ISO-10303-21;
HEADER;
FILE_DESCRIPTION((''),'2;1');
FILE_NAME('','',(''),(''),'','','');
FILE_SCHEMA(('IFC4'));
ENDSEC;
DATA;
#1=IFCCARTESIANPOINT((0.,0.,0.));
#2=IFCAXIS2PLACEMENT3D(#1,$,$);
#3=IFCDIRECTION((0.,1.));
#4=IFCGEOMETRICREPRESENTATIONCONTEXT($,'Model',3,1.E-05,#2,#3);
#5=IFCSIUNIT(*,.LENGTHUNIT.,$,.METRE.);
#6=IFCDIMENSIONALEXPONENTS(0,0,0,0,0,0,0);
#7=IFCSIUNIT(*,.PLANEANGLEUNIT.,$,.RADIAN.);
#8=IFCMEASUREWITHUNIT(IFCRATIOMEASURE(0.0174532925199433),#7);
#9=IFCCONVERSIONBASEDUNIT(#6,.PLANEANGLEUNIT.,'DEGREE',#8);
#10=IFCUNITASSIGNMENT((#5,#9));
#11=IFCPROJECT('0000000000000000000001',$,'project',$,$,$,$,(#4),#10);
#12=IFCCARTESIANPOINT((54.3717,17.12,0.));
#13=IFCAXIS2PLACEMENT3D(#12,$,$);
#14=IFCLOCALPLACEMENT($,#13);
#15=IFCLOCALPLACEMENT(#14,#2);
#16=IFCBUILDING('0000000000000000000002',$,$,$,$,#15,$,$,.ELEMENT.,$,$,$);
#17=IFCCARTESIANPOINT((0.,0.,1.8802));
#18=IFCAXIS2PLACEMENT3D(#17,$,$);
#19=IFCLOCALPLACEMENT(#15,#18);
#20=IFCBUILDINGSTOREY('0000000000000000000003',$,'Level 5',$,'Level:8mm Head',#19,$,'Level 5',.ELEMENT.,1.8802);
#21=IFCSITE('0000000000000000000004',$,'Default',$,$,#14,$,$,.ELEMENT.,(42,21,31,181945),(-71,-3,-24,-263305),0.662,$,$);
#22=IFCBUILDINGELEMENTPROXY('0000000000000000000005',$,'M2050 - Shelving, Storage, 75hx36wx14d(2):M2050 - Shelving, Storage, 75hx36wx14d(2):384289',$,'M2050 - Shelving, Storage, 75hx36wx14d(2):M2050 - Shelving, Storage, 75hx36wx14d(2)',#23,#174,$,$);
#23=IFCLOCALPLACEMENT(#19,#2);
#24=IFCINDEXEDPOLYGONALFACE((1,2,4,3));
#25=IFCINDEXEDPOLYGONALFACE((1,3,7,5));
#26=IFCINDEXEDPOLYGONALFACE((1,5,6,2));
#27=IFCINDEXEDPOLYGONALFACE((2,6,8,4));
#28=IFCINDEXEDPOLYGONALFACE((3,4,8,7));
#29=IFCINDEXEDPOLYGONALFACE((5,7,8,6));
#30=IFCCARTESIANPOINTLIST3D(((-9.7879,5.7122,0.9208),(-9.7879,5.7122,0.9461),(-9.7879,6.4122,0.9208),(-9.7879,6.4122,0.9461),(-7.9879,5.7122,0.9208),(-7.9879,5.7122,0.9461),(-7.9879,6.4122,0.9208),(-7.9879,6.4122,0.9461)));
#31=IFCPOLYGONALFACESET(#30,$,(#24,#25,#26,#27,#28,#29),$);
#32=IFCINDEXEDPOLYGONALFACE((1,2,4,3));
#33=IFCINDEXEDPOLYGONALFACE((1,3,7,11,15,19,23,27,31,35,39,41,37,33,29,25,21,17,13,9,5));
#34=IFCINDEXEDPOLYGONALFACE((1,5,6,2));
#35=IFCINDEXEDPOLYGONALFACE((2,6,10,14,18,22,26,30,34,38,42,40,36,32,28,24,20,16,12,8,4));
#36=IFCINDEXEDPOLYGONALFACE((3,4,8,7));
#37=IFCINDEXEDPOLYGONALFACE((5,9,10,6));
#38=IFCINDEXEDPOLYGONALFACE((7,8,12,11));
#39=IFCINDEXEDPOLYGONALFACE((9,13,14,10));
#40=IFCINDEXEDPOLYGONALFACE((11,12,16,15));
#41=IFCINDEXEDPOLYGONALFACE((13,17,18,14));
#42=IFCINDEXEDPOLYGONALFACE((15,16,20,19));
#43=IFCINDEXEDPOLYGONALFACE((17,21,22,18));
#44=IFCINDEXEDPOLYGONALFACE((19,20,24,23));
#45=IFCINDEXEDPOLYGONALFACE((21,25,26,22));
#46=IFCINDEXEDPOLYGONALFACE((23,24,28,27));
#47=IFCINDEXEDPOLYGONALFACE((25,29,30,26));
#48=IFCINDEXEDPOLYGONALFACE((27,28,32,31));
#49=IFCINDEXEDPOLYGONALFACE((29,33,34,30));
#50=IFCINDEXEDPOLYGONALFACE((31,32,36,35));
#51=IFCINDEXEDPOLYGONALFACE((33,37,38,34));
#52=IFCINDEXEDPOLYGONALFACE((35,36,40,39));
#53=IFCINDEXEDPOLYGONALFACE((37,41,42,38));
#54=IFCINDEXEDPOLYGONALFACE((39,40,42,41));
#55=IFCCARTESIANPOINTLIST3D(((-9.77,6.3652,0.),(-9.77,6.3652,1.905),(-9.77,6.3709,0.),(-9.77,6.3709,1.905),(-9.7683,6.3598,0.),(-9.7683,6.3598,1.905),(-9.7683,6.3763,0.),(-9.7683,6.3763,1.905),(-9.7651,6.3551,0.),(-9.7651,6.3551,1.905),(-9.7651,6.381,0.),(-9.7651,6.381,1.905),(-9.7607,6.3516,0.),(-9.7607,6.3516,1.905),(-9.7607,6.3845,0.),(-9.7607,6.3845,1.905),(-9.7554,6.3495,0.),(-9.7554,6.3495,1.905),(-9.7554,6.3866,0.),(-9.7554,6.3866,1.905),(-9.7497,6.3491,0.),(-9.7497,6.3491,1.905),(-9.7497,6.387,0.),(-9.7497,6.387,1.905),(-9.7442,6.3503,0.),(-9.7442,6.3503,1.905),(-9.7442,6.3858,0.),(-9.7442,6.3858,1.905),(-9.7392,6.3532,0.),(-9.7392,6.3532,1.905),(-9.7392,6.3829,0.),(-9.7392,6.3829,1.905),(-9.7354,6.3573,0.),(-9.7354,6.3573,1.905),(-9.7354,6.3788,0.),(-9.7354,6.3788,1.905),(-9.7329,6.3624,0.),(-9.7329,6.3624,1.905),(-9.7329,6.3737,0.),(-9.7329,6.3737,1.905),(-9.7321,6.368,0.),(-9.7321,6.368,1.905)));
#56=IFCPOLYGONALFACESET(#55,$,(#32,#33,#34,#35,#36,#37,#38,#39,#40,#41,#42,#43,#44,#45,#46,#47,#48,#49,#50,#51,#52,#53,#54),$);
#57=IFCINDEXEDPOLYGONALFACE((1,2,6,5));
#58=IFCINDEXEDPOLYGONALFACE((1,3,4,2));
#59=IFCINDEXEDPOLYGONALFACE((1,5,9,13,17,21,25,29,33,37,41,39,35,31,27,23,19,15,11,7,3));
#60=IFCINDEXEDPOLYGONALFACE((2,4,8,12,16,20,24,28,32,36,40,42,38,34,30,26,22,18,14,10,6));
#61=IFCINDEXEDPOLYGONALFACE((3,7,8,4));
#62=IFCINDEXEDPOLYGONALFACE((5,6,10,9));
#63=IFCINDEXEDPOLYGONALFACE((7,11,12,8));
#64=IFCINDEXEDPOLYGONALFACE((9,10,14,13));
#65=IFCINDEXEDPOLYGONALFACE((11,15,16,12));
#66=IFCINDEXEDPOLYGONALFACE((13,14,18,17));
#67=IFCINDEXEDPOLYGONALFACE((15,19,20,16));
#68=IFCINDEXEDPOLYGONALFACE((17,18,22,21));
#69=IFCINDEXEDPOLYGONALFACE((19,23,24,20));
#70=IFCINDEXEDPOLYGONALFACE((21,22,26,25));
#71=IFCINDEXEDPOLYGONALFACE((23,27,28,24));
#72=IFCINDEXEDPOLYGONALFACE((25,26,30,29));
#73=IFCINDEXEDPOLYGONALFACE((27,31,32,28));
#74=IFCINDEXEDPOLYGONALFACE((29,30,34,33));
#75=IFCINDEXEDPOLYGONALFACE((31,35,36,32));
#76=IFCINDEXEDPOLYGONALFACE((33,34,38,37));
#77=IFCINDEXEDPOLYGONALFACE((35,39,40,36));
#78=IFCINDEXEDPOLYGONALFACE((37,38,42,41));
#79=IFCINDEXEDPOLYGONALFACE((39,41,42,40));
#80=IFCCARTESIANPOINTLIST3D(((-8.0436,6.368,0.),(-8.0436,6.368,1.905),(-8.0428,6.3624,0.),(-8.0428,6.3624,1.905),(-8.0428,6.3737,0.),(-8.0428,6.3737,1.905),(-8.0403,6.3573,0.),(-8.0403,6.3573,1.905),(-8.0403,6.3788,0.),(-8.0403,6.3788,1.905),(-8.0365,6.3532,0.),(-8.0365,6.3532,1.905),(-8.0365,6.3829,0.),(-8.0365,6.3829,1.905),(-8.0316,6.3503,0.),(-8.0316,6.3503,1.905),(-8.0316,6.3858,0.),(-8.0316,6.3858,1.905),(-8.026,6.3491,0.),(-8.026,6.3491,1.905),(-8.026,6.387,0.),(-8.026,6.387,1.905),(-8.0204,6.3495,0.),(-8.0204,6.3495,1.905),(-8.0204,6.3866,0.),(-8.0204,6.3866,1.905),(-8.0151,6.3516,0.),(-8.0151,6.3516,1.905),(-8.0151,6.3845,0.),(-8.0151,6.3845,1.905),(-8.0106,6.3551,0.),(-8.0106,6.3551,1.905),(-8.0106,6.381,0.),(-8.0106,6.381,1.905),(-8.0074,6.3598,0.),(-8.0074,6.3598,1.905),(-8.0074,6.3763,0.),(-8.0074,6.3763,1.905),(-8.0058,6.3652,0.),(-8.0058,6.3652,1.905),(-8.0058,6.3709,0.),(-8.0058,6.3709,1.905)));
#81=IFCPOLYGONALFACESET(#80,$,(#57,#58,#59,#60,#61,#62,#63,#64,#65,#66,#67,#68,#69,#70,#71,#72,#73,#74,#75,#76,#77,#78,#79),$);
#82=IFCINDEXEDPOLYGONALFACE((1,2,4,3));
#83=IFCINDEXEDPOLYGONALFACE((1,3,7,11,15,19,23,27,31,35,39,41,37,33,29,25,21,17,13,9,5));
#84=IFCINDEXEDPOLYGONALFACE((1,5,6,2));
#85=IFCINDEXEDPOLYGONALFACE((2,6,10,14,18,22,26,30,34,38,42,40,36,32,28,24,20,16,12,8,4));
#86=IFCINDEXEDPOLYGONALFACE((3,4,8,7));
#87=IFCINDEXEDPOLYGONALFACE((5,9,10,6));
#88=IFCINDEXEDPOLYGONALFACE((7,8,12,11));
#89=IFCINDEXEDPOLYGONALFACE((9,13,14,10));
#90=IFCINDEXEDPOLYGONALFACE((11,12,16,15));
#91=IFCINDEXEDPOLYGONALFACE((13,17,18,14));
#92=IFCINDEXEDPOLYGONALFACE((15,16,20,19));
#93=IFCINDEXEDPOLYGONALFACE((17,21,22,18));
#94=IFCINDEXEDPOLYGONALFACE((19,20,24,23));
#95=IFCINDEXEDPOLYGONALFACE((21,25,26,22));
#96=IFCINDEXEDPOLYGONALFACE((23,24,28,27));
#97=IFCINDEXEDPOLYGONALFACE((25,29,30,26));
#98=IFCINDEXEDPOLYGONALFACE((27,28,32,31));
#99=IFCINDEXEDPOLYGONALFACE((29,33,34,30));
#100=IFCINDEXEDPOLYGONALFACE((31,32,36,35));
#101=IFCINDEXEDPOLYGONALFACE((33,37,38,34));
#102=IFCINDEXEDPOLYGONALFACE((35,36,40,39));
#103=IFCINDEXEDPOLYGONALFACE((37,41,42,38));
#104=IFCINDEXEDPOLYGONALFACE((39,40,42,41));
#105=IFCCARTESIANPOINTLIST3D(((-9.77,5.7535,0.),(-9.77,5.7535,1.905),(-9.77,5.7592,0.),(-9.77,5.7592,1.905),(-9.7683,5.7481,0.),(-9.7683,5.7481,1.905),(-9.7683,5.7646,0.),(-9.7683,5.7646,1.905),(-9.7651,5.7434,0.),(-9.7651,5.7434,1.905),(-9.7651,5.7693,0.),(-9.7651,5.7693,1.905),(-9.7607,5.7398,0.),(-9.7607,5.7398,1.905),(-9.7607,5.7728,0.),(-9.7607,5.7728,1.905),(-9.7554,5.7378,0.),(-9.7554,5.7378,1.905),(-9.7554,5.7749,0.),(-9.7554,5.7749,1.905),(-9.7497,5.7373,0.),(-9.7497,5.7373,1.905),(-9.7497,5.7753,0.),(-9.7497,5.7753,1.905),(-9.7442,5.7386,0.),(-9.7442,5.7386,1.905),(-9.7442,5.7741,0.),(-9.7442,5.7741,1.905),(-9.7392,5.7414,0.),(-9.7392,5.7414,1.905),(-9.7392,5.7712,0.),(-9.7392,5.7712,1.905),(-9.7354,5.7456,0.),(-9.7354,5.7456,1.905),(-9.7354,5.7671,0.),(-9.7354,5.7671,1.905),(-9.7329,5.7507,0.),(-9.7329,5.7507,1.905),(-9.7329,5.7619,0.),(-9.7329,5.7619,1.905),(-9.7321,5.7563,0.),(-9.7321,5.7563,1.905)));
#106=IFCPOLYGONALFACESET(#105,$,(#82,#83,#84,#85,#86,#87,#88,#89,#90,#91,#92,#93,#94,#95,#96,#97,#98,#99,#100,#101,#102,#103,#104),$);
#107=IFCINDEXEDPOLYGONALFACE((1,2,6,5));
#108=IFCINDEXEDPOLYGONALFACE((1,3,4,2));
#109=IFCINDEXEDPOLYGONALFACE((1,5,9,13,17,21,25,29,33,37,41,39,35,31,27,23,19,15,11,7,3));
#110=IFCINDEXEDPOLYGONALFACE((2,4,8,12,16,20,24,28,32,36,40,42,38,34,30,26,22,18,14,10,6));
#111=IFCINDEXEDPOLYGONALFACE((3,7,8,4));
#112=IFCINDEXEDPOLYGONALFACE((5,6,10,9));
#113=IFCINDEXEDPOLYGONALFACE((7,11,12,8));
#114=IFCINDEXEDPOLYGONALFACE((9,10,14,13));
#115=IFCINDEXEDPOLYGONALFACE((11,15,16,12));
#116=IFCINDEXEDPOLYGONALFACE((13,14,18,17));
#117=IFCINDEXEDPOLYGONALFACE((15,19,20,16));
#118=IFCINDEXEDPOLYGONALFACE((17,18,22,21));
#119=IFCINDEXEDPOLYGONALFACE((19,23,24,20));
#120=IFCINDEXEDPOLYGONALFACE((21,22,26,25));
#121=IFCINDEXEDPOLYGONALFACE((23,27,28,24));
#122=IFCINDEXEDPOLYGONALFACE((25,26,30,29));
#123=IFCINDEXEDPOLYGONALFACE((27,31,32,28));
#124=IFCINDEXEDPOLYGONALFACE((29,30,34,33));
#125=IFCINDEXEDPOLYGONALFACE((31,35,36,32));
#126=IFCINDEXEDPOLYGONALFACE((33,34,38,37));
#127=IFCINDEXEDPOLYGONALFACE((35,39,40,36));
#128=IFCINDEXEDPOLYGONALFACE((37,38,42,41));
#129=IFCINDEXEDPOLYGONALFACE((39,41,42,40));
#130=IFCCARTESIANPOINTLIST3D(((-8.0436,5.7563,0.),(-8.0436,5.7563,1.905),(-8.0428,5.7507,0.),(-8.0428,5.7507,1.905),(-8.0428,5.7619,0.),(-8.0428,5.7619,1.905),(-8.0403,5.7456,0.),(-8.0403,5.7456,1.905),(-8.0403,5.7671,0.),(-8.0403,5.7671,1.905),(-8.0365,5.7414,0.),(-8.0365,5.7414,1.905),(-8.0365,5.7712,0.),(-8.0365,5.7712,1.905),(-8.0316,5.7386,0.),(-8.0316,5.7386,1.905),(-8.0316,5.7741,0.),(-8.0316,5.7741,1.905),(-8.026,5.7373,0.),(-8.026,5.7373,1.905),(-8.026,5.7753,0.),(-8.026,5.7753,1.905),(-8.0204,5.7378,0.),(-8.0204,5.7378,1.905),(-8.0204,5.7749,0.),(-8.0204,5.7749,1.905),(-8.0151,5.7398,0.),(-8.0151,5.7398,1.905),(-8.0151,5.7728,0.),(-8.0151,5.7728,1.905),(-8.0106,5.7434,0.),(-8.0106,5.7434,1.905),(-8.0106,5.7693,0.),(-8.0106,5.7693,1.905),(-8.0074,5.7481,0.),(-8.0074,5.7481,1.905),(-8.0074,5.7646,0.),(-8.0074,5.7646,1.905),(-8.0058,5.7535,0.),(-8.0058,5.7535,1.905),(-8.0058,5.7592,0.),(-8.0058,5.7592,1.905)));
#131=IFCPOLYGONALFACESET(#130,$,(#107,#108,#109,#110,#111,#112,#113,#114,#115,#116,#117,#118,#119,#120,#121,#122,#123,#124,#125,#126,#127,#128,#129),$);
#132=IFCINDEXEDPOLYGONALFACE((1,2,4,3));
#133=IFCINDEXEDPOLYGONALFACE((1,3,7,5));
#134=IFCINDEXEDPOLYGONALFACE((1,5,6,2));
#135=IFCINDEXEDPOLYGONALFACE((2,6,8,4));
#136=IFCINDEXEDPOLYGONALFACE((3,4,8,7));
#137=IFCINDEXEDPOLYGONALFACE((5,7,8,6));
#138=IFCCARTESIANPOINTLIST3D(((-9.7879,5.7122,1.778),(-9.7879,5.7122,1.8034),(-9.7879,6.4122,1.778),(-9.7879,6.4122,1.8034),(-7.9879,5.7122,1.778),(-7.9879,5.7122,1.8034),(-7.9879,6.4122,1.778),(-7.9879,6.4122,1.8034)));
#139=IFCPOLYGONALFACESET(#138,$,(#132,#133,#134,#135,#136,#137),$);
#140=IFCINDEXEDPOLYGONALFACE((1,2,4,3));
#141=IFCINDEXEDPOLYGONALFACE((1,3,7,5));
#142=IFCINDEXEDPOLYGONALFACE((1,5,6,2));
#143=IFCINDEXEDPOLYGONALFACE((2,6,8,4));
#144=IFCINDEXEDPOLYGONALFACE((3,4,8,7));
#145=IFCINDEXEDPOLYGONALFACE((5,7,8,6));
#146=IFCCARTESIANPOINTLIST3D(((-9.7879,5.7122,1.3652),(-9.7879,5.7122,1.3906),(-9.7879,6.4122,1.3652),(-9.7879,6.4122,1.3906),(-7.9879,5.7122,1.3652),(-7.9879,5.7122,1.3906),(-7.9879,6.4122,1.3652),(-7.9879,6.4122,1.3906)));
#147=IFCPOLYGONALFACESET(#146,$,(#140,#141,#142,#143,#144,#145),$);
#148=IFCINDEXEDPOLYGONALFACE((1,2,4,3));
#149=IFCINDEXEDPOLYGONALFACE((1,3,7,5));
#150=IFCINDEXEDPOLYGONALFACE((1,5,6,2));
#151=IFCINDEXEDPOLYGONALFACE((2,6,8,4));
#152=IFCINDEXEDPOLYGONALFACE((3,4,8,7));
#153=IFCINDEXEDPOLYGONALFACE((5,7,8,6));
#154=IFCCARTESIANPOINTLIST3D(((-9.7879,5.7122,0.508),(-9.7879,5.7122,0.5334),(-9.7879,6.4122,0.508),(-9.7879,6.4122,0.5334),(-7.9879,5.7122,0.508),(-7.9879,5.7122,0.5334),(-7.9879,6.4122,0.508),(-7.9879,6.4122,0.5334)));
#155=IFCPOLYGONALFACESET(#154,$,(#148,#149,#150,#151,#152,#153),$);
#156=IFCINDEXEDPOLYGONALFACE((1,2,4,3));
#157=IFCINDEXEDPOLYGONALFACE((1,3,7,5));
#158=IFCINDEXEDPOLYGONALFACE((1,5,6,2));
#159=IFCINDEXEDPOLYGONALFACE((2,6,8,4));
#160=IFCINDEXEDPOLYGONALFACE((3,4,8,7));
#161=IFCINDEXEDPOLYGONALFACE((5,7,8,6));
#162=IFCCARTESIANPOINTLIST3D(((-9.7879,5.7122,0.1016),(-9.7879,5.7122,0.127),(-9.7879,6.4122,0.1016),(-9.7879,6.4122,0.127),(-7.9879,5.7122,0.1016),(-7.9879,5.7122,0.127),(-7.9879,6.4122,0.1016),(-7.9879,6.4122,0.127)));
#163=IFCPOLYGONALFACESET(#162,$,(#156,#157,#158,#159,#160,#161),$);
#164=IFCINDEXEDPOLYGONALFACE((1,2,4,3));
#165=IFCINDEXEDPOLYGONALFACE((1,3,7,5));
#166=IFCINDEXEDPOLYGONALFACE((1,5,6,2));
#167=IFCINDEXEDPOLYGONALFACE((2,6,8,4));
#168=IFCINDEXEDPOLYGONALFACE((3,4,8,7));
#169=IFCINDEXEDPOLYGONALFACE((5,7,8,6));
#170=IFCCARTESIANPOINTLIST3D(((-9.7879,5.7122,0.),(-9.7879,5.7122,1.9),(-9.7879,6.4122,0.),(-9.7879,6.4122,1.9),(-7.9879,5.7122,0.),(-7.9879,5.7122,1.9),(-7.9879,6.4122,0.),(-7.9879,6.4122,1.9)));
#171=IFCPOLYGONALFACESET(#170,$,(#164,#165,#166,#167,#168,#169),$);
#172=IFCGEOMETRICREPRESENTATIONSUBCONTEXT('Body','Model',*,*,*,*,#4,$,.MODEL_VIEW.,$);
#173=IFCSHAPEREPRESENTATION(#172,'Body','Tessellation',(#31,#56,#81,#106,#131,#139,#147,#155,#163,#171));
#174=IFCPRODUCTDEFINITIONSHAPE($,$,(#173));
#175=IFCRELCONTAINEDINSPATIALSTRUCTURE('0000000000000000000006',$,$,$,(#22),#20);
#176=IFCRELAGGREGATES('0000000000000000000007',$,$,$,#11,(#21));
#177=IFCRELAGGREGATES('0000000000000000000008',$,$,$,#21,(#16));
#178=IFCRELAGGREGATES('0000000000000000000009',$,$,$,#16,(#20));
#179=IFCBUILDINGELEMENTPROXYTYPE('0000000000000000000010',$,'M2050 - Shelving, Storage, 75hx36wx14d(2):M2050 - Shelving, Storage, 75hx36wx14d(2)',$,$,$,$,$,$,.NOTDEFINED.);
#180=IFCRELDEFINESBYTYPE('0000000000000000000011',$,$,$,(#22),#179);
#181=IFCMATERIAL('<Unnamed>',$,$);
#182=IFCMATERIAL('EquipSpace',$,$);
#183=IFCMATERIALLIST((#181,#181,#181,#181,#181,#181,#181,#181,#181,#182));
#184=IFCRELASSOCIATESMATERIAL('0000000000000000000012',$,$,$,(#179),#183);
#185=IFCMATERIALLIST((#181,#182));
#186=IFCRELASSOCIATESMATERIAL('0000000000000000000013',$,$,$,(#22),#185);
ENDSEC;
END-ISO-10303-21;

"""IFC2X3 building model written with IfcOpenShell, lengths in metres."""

from ifc_helpers import new_model, entity, si_unit, converted_unit, direction, frame, frame_2d, origin, origin_2d_with_axis, place, context, subcontext, project, spatial, rectangle, circle, extrude, source, transform, mapped, material, material_list, type_object, type_shapes, element, save


model = new_model("IFC2X3")

# Units and contexts
model_context = context("Model", 3, precision=1e-05, world=origin(), true_north=direction((0.0, 1.0)))
body_context = subcontext(model_context, "Body", "Model", "MODEL_VIEW")
ifc_project = project(units=[si_unit("LENGTHUNIT", "METRE"), converted_unit("PLANEANGLEUNIT", "DEGREE", entity("IfcRatioMeasure", 0.0174532925199433), si_unit("PLANEANGLEUNIT", "RADIAN"), dimensions=[0, 0, 0, 0, 0, 0, 0])], contexts=[model_context])

# Site, building, storey
site_placement = place(None, frame((54.3717, 17.12, 0.0)))
site = spatial("IfcSite", under=ifc_project, at=site_placement, Name="Default", CompositionType="ELEMENT", RefLatitude=(42, 21, 31, 181945), RefLongitude=(-71, -3, -24, -263305), RefElevation=0.662)
building_placement = place(site_placement, origin())
building = spatial("IfcBuilding", under=site, at=building_placement, CompositionType="ELEMENT")
storey_placement = place(building_placement, frame((0.0, 0.0, 1.8802)))
storey = spatial("IfcBuildingStorey", under=building, at=storey_placement, Name="Level 5", ObjectType="Level:8mm Head", LongName="Level 5", CompositionType="ELEMENT", Elevation=1.8802)

# Building element proxy
ifc_material_1 = material(Name="<Unnamed>")
ifc_material_2 = material(Name="EquipSpace")
ifc_material_list_1 = material_list([ifc_material_1, ifc_material_1, ifc_material_1, ifc_material_1, ifc_material_1, ifc_material_1, ifc_material_1, ifc_material_1, ifc_material_1, ifc_material_2])
building_element_proxy_type = type_object("IfcBuildingElementProxyType", Name="M2050 - Shelving, Storage, 75hx36wx14d(2):M2050 - Shelving, Storage, 75hx36wx14d(2)", PredefinedType="NOTDEFINED", material=ifc_material_list_1)
shared_shape = source(origin(), body_context, "Body", "SweptSolid", [
    extrude(rectangle(XDim=1.8, YDim=0.7, at=origin_2d_with_axis()), frame((0.0, 0.0, 0.9207), z_axis=(0.0, 0.0, 1.0), x_axis=(-1.0, 0.0, 0.0)), (0.0, 0.0, 1.0), 0.0254),
    extrude(circle(Radius=0.0191, at=origin_2d_with_axis()), frame((0.8633, -0.3059, 0.0), z_axis=(0.0, 0.0, 1.0), x_axis=(-1.0, 0.0, 0.0)), (0.0, 0.0, 1.0), 1.905),
    extrude(circle(Radius=0.0191, at=origin_2d_with_axis()), frame((-0.8633, -0.3059, 0.0)), (0.0, 0.0, 1.0), 1.905),
    extrude(circle(Radius=0.0191, at=origin_2d_with_axis()), frame((0.8633, 0.3059, 0.0), z_axis=(0.0, 0.0, 1.0), x_axis=(-1.0, 0.0, 0.0)), (0.0, 0.0, 1.0), 1.905),
    extrude(circle(Radius=0.0191, at=origin_2d_with_axis()), frame((-0.8633, 0.3059, 0.0)), (0.0, 0.0, 1.0), 1.905),
    extrude(rectangle(XDim=1.8, YDim=0.7, at=origin_2d_with_axis()), frame((0.0, 0.0, 1.778), z_axis=(0.0, 0.0, 1.0), x_axis=(-1.0, 0.0, 0.0)), (0.0, 0.0, 1.0), 0.0254),
    extrude(rectangle(XDim=1.8, YDim=0.7, at=origin_2d_with_axis()), frame((0.0, 0.0, 1.3653), z_axis=(0.0, 0.0, 1.0), x_axis=(-1.0, 0.0, 0.0)), (0.0, 0.0, 1.0), 0.0254),
    extrude(rectangle(XDim=1.8, YDim=0.7, at=origin_2d_with_axis()), frame((0.0, 0.0, 0.508), z_axis=(0.0, 0.0, 1.0), x_axis=(-1.0, 0.0, 0.0)), (0.0, 0.0, 1.0), 0.0254),
    extrude(rectangle(XDim=1.8, YDim=0.7, at=origin_2d_with_axis()), frame((0.0, 0.0, 0.1016), z_axis=(0.0, 0.0, 1.0), x_axis=(-1.0, 0.0, 0.0)), (0.0, 0.0, 1.0), 0.0254),
    extrude(rectangle(XDim=0.7, YDim=1.8, at=frame_2d((0.0, 0.18), x_axis=(1.0, 0.0))), frame((-0.18, 0.0, 0.0), z_axis=(0.0, 0.0, 1.0), x_axis=(0.0, -1.0, 0.0)), (0.0, 0.0, 1.0), 1.9),
])
type_shapes(building_element_proxy_type, [shared_shape])
ifc_material_list_2 = material_list([ifc_material_1, ifc_material_2])
proxy_1_placement = place(storey_placement, frame((-8.8879, 6.0622, 0.0), z_axis=(0.0, 0.0, 1.0), x_axis=(-1.0, 0.0, 0.0)))
element("IfcBuildingElementProxy", 1, at=proxy_1_placement, inside=storey, type_object=building_element_proxy_type, material=ifc_material_list_2, Name="M2050 - Shelving, Storage, 75hx36wx14d(2):M2050 - Shelving, Storage, 75hx36wx14d(2):384289", ObjectType="M2050 - Shelving, Storage, 75hx36wx14d(2):M2050 - Shelving, Storage, 75hx36wx14d(2)", context=body_context, shape_type="MappedRepresentation", body=[
    mapped(shared_shape, transform((0.0, 0.0, 0.0), scale=1.0)),
])

save(model, "model.ifc")
